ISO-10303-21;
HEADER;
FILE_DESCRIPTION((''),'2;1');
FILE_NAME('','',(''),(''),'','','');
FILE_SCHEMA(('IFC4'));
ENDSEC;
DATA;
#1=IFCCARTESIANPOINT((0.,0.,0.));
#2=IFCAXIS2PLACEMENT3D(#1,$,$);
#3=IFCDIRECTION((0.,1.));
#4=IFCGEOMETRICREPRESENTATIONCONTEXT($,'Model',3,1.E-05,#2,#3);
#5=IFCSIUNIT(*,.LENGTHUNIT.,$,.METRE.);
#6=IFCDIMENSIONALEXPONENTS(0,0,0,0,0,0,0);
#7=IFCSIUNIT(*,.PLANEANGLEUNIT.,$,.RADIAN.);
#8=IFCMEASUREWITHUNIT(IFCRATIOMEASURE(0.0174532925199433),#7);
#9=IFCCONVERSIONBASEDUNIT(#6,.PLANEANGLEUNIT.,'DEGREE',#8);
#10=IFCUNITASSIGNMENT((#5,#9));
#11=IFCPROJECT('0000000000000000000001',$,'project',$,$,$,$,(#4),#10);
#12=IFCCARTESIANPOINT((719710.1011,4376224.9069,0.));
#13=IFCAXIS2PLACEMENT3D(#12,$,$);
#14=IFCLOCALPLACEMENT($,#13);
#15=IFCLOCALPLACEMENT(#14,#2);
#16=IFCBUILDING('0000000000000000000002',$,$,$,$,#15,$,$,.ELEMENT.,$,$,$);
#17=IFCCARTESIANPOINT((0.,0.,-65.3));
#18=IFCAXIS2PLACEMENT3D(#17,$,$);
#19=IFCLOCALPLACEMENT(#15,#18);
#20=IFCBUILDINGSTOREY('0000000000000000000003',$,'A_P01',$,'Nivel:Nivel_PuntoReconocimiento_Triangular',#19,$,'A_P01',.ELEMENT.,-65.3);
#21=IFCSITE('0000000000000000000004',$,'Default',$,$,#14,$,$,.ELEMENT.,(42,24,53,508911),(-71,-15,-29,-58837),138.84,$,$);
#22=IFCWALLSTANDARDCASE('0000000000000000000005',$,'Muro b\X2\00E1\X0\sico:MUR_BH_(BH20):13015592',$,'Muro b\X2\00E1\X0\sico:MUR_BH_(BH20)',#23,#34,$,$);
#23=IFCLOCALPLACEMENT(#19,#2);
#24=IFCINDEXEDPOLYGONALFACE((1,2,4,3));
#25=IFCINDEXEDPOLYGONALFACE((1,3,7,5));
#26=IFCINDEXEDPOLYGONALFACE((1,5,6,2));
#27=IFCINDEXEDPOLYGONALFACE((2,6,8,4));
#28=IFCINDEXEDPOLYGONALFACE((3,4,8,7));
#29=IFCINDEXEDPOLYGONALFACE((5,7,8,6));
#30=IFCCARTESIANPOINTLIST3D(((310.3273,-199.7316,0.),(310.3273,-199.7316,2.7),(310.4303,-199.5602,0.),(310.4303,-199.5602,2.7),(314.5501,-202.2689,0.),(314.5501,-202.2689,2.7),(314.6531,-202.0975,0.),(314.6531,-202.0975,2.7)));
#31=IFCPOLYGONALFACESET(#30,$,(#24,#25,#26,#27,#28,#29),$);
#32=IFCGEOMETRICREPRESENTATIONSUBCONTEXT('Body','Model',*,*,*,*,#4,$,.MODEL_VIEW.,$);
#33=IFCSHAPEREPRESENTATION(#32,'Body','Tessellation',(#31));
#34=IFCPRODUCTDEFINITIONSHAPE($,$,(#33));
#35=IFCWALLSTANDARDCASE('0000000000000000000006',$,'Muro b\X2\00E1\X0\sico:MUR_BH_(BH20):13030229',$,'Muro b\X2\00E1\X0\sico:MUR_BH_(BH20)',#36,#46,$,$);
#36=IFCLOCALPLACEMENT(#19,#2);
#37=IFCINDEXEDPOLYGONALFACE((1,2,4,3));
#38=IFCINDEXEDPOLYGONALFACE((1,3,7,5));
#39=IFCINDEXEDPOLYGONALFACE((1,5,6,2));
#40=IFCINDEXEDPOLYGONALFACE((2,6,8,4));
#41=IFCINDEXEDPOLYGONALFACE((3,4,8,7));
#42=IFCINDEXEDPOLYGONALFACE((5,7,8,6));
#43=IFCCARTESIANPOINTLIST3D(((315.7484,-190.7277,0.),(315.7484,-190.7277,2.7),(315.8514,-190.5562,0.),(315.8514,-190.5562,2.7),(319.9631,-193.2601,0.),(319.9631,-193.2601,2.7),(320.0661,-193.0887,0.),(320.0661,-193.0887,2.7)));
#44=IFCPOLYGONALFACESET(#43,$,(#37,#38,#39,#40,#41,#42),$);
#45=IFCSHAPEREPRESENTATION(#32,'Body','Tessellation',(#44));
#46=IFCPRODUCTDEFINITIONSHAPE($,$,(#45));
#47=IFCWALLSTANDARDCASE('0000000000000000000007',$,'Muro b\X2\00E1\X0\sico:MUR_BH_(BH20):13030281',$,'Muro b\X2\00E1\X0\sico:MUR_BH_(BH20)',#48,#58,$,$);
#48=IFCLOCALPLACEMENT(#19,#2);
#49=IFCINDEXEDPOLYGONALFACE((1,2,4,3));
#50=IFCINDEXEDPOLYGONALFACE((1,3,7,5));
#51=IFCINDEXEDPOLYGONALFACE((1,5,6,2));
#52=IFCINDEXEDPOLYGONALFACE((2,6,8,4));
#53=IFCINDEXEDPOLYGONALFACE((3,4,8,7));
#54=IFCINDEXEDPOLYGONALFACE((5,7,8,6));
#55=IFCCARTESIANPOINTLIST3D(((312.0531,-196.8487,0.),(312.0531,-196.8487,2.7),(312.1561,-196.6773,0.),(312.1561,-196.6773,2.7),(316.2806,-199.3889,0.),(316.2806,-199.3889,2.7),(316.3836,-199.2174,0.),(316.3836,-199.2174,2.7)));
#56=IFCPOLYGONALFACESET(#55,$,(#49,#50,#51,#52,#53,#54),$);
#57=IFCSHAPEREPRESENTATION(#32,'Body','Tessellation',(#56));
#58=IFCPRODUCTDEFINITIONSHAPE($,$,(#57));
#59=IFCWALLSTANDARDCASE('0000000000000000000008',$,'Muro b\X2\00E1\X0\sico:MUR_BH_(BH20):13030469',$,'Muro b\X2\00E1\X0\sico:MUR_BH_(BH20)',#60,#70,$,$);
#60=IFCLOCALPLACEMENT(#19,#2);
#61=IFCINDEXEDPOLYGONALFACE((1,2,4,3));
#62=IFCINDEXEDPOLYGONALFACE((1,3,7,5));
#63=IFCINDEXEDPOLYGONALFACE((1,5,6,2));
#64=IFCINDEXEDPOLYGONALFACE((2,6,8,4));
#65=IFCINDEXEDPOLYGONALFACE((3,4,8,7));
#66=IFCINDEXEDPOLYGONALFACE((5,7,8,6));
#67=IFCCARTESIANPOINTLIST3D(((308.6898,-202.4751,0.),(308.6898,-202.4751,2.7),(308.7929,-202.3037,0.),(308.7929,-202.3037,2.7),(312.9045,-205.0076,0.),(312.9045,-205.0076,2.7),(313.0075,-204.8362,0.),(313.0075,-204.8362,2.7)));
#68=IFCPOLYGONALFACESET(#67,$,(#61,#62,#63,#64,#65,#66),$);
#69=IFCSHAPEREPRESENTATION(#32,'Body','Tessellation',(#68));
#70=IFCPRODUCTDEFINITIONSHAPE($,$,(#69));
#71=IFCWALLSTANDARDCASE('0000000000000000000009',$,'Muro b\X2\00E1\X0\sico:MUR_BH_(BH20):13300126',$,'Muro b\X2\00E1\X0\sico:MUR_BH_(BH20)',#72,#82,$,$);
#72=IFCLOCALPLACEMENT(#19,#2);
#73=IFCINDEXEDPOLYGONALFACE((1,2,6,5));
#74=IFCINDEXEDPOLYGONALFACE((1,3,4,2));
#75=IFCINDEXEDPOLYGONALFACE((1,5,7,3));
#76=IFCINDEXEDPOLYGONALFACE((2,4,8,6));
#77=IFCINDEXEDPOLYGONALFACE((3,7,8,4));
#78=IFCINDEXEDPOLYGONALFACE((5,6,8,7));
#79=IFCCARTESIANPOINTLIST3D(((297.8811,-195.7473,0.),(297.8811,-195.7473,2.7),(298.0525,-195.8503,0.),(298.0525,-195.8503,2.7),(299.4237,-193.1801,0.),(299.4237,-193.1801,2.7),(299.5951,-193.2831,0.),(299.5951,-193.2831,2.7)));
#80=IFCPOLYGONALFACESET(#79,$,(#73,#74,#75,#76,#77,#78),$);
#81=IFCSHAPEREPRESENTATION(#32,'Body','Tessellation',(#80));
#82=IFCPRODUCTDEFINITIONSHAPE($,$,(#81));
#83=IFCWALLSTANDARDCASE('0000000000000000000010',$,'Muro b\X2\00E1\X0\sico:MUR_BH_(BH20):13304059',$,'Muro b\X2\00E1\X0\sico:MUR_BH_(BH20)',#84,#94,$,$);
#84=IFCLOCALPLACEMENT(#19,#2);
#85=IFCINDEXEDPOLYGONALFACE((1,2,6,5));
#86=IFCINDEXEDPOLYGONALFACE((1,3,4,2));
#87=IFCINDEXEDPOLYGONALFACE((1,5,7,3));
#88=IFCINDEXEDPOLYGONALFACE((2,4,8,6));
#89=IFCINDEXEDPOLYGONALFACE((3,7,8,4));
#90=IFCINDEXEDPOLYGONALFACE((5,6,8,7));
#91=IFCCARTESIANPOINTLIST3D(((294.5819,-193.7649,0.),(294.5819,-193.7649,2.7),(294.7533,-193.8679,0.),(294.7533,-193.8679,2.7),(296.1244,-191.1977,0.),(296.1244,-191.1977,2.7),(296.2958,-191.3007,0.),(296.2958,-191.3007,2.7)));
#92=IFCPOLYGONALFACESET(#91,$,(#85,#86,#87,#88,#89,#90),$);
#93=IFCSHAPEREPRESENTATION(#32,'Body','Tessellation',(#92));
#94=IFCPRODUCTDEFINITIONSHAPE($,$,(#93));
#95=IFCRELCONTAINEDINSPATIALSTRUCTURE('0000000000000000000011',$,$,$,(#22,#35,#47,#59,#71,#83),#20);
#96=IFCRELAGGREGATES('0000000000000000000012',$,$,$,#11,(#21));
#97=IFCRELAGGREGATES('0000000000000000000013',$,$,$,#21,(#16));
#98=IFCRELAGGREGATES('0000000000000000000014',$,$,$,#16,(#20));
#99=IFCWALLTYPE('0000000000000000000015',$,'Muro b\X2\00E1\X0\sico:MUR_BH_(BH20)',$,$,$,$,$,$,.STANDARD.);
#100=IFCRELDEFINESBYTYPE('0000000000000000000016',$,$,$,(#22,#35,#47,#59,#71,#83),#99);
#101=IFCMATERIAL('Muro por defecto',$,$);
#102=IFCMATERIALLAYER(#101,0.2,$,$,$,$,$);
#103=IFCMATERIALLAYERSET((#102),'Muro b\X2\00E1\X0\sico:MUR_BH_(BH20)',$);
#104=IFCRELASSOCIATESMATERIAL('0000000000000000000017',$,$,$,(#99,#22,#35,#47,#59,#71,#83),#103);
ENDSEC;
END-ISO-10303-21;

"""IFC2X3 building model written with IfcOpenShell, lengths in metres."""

from ifc_helpers import new_model, entity, si_unit, converted_unit, direction, frame, frame_2d, origin, place, context, subcontext, project, spatial, rectangle, extrude, material, layer, layer_set, layer_usage, type_object, element, save


model = new_model("IFC2X3")

# Units and contexts
model_context = context("Model", 3, precision=1e-05, world=origin(), true_north=direction((0.0, 1.0)))
body_context = subcontext(model_context, "Body", "Model", "MODEL_VIEW")
ifc_project = project(units=[si_unit("LENGTHUNIT", "METRE"), converted_unit("PLANEANGLEUNIT", "DEGREE", entity("IfcRatioMeasure", 0.0174532925199433), si_unit("PLANEANGLEUNIT", "RADIAN"), dimensions=[0, 0, 0, 0, 0, 0, 0])], contexts=[model_context])

# Site, building, storey
site_placement = place(None, frame((719710.1011, 4376224.9069, 0.0)))
site = spatial("IfcSite", under=ifc_project, at=site_placement, Name="Default", CompositionType="ELEMENT", RefLatitude=(42, 24, 53, 508911), RefLongitude=(-71, -15, -29, -58837), RefElevation=138.84)
building_placement = place(site_placement, origin())
building = spatial("IfcBuilding", under=site, at=building_placement, CompositionType="ELEMENT")
storey_placement = place(building_placement, frame((0.0, 0.0, -65.3)))
storey = spatial("IfcBuildingStorey", under=building, at=storey_placement, Name="A_P01", ObjectType="Nivel:Nivel_PuntoReconocimiento_Triangular", LongName="A_P01", CompositionType="ELEMENT", Elevation=-65.3)

# Shared definitions
ifc_material_1 = material(Name="Muro por defecto")
ifc_layer = layer(ifc_material_1, 0.2)
ifc_layer_set = layer_set([ifc_layer], Name="Muro básico:MUR_BH_(BH20)")
wall_type = type_object("IfcWallType", Name="Muro básico:MUR_BH_(BH20)", PredefinedType="STANDARD", material=ifc_layer_set)

# Walls
ifc_layer_usage_1 = layer_usage(ifc_layer_set, "AXIS2", "NEGATIVE", 0.1)
wall_1_placement = place(storey_placement, frame((310.3788, -199.6459, 0.0), z_axis=(0.0, 0.0, 1.0), x_axis=(0.857167, -0.515038, 0.0)))
element("IfcWallStandardCase", 1, at=wall_1_placement, inside=storey, type_object=wall_type, material=ifc_layer_usage_1, Name="Muro básico:MUR_BH_(BH20):13015592", ObjectType="Muro básico:MUR_BH_(BH20)", context=body_context, shape_type="SweptSolid", body=[
    extrude(rectangle(XDim=4.9264, YDim=0.2, at=frame_2d((2.4632, 0.0), x_axis=(-1.0, 0.0))), origin(), (0.0, 0.0, 1.0), 2.7),
])
ifc_layer_usage_2 = layer_usage(ifc_layer_set, "AXIS2", "NEGATIVE", 0.1)
wall_2_placement = place(storey_placement, frame((315.7999, -190.6419, 0.0), z_axis=(0.0, 0.0, 1.0), x_axis=(0.857167, -0.515038, 0.0)))
element("IfcWallStandardCase", 2, at=wall_2_placement, inside=storey, type_object=wall_type, material=ifc_layer_usage_2, Name="Muro básico:MUR_BH_(BH20):13030229", ObjectType="Muro básico:MUR_BH_(BH20)", context=body_context, shape_type="SweptSolid", body=[
    extrude(rectangle(XDim=4.917, YDim=0.2, at=frame_2d((2.4585, 0.0), x_axis=(-1.0, 0.0))), origin(), (0.0, 0.0, 1.0), 2.7),
])
ifc_layer_usage_3 = layer_usage(ifc_layer_set, "AXIS2", "NEGATIVE", 0.1)
wall_3_placement = place(storey_placement, frame((312.1046, -196.763, 0.0), z_axis=(0.0, 0.0, 1.0), x_axis=(0.857167, -0.515038, 0.0)))
element("IfcWallStandardCase", 3, at=wall_3_placement, inside=storey, type_object=wall_type, material=ifc_layer_usage_3, Name="Muro básico:MUR_BH_(BH20):13030281", ObjectType="Muro básico:MUR_BH_(BH20)", context=body_context, shape_type="SweptSolid", body=[
    extrude(rectangle(XDim=4.932, YDim=0.2, at=frame_2d((2.466, 0.0), x_axis=(-1.0, 0.0))), origin(), (0.0, 0.0, 1.0), 2.7),
])
ifc_layer_usage_4 = layer_usage(ifc_layer_set, "AXIS2", "NEGATIVE", 0.1)
wall_4_placement = place(storey_placement, frame((308.7413, -202.3894, 0.0), z_axis=(0.0, 0.0, 1.0), x_axis=(0.857167, -0.515038, 0.0)))
element("IfcWallStandardCase", 4, at=wall_4_placement, inside=storey, type_object=wall_type, material=ifc_layer_usage_4, Name="Muro básico:MUR_BH_(BH20):13030469", ObjectType="Muro básico:MUR_BH_(BH20)", context=body_context, shape_type="SweptSolid", body=[
    extrude(rectangle(XDim=4.917, YDim=0.2, at=frame_2d((2.4585, 0.0), x_axis=(-1.0, 0.0))), origin(), (0.0, 0.0, 1.0), 2.7),
])
ifc_layer_usage_5 = layer_usage(ifc_layer_set, "AXIS2", "NEGATIVE", 0.1)
wall_5_placement = place(storey_placement, frame((299.5094, -193.2316, 0.0), z_axis=(0.0, 0.0, 1.0), x_axis=(-0.515038, -0.857167, 0.0)))
element("IfcWallStandardCase", 5, at=wall_5_placement, inside=storey, type_object=wall_type, material=ifc_layer_usage_5, Name="Muro básico:MUR_BH_(BH20):13300126", ObjectType="Muro básico:MUR_BH_(BH20)", context=body_context, shape_type="SweptSolid", body=[
    extrude(rectangle(XDim=2.995, YDim=0.2, at=frame_2d((1.4975, 0.0), x_axis=(-1.0, 0.0))), origin(), (0.0, 0.0, 1.0), 2.7),
])
ifc_layer_usage_6 = layer_usage(ifc_layer_set, "AXIS2", "NEGATIVE", 0.1)
wall_6_placement = place(storey_placement, frame((296.2101, -191.2492, 0.0), z_axis=(0.0, 0.0, 1.0), x_axis=(-0.515038, -0.857167, 0.0)))
element("IfcWallStandardCase", 6, at=wall_6_placement, inside=storey, type_object=wall_type, material=ifc_layer_usage_6, Name="Muro básico:MUR_BH_(BH20):13304059", ObjectType="Muro básico:MUR_BH_(BH20)", context=body_context, shape_type="SweptSolid", body=[
    extrude(rectangle(XDim=2.995, YDim=0.2, at=frame_2d((1.4975, 0.0), x_axis=(-1.0, 0.0))), origin(), (0.0, 0.0, 1.0), 2.7),
])

save(model, "model.ifc")
